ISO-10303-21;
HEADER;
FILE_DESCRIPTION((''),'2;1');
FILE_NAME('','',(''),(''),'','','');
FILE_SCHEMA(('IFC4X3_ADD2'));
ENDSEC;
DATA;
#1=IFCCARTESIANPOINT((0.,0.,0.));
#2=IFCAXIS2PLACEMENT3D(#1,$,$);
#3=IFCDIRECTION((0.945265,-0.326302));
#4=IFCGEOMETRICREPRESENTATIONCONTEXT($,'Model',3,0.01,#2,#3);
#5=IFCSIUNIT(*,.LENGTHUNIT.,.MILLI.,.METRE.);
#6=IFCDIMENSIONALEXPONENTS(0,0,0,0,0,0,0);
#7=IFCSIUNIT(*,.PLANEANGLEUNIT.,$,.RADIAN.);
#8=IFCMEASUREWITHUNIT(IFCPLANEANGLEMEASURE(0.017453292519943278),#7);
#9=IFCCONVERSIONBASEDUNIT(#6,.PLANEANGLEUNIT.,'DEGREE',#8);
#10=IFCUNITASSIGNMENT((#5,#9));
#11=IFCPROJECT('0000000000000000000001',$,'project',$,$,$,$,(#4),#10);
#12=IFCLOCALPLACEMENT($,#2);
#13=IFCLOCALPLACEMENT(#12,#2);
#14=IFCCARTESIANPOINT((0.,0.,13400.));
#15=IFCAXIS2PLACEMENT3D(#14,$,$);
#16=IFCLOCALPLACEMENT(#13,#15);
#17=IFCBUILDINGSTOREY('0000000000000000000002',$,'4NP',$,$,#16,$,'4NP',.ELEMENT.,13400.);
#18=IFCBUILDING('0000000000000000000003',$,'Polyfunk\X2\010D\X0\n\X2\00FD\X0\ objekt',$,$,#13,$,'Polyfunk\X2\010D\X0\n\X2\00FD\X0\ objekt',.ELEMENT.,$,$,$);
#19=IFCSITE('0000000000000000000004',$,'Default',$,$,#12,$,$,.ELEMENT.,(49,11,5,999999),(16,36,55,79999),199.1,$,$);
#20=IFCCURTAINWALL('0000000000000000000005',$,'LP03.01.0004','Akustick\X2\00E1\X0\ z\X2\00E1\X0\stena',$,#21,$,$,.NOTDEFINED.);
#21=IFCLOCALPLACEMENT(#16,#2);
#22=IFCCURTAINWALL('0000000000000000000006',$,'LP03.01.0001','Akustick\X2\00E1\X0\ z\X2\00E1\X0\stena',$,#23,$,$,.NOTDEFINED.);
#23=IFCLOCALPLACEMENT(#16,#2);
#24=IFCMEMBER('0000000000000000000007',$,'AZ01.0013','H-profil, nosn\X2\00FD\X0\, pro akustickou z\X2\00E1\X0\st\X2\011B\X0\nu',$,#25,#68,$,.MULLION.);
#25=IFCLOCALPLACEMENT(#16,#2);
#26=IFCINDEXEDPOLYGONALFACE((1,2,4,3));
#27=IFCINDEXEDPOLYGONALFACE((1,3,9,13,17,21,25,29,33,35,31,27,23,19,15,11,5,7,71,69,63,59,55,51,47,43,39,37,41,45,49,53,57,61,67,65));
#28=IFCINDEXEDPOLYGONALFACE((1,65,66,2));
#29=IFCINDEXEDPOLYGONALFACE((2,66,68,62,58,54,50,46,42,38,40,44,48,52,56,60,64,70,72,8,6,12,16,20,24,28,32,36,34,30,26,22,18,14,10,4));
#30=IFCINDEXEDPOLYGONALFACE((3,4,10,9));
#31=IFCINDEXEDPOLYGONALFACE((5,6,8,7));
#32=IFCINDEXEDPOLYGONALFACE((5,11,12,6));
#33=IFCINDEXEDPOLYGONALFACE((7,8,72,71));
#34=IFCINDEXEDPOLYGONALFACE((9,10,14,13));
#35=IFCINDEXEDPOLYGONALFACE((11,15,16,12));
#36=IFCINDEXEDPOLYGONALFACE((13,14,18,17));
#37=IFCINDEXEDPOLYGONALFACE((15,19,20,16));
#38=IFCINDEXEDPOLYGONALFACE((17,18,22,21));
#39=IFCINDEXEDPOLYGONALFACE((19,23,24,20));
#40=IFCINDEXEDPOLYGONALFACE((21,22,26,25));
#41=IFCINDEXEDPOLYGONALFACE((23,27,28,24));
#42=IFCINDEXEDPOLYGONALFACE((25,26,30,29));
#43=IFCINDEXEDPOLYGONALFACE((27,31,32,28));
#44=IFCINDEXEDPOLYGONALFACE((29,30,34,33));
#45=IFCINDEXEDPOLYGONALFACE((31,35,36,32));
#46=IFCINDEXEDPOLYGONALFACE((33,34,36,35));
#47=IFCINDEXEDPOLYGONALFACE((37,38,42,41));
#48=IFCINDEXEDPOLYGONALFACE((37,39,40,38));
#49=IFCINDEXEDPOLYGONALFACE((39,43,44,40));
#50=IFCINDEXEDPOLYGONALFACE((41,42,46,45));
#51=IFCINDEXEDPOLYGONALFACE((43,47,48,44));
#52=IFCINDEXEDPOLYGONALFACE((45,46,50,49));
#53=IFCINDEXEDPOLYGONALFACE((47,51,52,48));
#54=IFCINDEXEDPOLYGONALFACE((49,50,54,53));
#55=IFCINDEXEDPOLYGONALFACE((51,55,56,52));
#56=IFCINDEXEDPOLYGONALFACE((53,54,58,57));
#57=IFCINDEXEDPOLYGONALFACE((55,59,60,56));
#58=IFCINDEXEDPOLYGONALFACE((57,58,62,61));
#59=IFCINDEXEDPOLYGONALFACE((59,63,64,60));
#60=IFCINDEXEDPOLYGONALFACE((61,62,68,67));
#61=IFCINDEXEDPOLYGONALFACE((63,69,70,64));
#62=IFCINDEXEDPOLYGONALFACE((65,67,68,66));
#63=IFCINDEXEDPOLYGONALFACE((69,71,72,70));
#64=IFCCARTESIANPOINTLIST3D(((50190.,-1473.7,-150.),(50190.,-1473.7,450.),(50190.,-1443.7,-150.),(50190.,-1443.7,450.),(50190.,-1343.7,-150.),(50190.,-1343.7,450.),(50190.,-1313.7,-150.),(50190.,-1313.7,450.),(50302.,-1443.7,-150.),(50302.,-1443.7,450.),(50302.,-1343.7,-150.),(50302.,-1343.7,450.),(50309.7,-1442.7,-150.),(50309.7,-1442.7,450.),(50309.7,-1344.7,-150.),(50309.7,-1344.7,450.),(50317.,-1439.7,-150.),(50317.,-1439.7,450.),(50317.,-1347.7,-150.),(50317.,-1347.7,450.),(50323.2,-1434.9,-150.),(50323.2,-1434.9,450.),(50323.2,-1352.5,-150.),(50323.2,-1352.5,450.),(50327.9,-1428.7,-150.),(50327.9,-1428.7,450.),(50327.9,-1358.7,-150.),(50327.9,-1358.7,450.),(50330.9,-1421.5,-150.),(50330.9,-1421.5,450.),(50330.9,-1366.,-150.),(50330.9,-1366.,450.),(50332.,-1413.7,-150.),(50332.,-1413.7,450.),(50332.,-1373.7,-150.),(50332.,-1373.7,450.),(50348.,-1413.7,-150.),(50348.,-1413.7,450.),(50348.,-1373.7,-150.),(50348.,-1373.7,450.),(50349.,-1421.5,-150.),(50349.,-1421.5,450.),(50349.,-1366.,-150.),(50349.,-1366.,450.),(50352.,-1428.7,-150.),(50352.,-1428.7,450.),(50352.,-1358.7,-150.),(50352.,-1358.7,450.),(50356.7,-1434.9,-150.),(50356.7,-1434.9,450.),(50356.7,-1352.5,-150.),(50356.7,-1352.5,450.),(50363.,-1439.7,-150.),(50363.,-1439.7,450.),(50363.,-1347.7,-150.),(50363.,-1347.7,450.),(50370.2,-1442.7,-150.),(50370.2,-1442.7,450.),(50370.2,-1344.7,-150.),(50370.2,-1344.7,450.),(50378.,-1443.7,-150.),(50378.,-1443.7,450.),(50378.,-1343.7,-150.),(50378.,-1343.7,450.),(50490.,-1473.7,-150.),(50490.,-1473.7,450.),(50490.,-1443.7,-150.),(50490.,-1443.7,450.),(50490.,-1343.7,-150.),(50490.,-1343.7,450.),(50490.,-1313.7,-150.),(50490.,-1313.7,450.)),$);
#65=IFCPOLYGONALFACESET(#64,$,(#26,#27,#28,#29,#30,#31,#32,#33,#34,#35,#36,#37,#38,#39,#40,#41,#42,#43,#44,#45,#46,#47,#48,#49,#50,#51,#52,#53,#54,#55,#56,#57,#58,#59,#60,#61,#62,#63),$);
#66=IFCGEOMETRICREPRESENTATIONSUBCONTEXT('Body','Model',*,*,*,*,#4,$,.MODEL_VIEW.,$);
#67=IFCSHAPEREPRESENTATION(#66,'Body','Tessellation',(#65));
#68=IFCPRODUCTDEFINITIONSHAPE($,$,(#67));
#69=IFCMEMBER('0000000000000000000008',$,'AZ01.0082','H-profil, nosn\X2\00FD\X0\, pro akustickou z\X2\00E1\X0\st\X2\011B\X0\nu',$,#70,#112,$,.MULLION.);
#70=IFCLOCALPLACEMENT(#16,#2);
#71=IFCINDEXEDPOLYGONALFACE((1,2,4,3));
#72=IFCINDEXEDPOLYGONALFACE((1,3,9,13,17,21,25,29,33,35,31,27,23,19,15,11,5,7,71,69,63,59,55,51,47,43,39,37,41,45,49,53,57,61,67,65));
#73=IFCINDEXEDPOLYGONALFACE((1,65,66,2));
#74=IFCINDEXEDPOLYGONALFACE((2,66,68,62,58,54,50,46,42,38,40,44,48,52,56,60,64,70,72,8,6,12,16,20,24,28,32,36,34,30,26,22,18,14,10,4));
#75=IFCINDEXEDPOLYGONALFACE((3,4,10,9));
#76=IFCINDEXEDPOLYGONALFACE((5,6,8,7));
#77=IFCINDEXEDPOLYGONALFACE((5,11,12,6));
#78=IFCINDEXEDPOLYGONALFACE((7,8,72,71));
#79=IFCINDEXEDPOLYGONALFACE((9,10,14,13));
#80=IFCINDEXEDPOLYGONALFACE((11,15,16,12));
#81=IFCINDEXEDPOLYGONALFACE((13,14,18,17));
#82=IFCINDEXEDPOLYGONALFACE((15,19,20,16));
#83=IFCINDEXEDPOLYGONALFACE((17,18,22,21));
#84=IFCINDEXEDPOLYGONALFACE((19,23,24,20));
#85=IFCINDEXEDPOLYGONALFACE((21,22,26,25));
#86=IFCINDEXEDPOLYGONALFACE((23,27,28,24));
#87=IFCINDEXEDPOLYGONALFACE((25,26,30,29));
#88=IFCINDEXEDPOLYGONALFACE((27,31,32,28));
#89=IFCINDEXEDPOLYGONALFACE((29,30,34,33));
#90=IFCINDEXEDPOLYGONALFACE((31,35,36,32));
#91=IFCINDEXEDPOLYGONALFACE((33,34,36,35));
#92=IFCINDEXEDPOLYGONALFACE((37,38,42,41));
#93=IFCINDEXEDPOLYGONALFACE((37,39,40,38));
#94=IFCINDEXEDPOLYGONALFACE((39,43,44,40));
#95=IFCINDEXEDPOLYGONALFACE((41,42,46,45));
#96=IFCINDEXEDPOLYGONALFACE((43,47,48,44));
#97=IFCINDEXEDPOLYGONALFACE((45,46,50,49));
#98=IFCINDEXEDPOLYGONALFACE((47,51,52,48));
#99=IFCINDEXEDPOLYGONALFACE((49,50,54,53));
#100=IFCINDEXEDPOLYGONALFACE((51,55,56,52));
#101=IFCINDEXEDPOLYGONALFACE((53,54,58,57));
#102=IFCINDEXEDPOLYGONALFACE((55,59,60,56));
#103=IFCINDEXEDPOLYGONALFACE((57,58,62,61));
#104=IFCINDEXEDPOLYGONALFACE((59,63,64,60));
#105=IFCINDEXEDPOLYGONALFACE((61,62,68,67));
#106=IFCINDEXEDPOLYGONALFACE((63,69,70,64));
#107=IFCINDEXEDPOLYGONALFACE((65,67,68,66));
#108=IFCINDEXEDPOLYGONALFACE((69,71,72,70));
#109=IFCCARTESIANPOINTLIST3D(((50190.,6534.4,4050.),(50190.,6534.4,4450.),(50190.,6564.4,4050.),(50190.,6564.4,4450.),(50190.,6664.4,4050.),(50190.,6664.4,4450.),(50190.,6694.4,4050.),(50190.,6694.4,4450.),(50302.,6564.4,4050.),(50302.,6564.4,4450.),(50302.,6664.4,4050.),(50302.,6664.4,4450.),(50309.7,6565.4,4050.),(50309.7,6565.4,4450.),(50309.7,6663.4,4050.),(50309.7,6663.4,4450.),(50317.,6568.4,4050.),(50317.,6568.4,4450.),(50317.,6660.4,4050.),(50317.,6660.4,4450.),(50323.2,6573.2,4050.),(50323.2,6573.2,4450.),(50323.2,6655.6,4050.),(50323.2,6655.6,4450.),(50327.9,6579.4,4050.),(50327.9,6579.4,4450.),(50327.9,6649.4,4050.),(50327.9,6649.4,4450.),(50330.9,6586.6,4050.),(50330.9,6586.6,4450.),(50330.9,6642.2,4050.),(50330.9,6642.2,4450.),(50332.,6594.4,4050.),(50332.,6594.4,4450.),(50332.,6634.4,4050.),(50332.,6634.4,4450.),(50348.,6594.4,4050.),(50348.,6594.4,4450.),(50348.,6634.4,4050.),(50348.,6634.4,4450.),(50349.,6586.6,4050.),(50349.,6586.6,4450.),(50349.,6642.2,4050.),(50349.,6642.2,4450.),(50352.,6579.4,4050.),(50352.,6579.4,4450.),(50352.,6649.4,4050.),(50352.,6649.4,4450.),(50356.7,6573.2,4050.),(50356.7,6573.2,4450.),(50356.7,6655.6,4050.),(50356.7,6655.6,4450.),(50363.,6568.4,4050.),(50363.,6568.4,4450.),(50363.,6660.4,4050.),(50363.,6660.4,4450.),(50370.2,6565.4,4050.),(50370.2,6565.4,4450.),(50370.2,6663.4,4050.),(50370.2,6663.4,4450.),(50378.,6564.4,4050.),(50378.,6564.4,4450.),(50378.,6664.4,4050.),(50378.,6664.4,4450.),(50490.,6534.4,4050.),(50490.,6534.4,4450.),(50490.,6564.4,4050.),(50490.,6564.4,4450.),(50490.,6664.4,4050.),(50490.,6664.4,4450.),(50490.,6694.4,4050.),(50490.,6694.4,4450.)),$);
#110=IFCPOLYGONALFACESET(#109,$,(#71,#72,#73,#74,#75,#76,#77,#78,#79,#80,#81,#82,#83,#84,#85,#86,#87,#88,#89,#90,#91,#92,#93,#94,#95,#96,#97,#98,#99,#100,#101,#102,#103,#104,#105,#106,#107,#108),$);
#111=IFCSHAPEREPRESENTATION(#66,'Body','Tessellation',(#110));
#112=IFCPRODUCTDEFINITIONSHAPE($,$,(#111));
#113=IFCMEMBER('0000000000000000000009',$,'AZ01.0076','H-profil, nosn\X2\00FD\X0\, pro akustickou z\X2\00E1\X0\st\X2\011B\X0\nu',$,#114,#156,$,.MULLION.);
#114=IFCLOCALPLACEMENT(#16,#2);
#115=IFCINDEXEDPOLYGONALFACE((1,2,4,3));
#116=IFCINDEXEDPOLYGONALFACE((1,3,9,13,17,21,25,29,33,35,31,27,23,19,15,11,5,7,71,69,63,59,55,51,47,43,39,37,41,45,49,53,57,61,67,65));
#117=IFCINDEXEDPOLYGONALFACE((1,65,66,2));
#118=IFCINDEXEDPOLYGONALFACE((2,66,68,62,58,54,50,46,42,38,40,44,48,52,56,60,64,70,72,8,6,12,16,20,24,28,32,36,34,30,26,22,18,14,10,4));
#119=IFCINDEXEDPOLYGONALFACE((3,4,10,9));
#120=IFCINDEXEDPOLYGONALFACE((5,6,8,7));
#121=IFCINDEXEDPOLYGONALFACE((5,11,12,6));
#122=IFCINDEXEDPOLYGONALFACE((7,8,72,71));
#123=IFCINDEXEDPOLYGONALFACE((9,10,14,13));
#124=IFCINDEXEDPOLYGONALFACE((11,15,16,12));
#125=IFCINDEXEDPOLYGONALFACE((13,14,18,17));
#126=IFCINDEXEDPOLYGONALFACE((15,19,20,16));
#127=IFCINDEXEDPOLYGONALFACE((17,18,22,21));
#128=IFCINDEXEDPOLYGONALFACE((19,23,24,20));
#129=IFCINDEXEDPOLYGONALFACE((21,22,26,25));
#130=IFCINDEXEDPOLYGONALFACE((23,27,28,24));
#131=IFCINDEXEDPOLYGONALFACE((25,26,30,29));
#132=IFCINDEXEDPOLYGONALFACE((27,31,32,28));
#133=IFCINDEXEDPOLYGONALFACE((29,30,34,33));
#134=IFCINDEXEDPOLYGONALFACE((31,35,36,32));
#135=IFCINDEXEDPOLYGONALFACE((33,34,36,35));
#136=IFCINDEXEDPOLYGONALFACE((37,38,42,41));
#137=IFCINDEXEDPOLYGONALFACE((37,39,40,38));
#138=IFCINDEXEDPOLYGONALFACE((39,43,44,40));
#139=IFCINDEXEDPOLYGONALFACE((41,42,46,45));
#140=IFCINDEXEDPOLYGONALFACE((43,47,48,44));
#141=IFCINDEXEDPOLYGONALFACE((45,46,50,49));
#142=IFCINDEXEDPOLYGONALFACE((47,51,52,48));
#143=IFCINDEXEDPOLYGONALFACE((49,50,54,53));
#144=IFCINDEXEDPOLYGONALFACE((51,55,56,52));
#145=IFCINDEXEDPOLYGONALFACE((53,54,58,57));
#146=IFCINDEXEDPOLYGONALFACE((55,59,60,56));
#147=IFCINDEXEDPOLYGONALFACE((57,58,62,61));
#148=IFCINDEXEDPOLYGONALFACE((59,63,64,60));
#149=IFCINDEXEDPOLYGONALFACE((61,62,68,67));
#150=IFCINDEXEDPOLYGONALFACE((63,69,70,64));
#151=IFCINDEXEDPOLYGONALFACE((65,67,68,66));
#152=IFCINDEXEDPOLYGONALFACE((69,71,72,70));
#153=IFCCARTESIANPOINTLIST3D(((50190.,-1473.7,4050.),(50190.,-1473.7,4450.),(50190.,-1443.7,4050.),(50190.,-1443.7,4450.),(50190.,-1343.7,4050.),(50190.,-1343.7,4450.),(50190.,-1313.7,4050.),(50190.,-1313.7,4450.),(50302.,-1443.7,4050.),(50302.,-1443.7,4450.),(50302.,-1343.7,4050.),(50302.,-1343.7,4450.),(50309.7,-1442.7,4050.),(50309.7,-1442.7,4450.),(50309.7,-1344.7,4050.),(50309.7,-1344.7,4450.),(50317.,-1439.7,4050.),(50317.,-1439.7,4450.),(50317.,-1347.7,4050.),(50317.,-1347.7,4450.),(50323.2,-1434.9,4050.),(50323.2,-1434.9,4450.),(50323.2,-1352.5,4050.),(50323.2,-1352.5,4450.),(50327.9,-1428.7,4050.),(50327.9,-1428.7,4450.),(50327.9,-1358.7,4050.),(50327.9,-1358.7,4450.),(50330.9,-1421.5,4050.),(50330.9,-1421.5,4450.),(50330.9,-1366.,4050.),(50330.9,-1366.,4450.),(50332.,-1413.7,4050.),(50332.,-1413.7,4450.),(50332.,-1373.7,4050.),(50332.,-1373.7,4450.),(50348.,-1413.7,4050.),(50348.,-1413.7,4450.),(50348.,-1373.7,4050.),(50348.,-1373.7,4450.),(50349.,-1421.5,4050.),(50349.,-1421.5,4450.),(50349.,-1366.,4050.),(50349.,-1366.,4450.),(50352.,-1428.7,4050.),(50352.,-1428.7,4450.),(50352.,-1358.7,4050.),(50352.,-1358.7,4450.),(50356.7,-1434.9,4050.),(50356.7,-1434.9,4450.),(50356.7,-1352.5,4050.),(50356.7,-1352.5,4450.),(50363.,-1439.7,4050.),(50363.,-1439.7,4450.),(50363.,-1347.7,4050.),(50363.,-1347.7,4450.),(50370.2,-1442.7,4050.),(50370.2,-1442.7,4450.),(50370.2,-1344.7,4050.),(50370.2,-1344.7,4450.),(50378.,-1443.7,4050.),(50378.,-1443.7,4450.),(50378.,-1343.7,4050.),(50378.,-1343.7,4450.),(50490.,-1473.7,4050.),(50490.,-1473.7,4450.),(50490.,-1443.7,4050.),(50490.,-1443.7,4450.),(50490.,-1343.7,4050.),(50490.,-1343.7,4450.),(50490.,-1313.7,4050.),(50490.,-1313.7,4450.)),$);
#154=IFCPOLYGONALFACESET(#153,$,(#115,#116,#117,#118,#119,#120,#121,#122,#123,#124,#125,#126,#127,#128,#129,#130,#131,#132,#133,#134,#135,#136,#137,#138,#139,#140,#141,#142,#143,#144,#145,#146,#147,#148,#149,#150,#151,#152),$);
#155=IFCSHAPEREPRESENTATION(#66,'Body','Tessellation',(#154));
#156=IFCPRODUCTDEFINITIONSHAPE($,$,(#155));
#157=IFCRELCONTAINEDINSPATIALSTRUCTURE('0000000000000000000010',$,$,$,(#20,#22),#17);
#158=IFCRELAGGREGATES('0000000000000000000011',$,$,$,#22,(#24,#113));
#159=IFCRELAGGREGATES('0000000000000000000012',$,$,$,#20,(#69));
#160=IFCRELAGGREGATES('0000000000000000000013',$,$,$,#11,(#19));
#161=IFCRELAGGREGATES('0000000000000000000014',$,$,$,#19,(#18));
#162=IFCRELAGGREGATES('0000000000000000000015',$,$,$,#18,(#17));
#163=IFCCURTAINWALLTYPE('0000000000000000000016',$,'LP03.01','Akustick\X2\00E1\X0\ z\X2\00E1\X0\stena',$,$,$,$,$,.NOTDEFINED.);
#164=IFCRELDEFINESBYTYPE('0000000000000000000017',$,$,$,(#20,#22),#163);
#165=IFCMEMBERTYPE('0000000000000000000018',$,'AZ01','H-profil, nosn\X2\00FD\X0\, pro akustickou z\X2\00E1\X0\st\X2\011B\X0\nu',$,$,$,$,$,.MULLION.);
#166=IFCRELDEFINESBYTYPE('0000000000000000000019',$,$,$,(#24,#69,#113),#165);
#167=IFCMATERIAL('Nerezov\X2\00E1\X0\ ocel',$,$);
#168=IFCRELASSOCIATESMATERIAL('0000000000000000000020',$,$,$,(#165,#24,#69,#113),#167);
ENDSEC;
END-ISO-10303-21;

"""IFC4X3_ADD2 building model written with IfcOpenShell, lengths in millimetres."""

from ifc_helpers import new_model, entity, si_unit, converted_unit, direction, frame, frame_2d, origin, place, context, subcontext, project, spatial, polyline, circle_curve, parameter, trimmed, segment, composite_curve, outline, extrude, source, transform, mapped, material, material_profile, profile_set, profile_usage, type_object, element, aggregate, save


model = new_model("IFC4X3_ADD2")

# Units and contexts
model_context = context("Model", 3, precision=0.01, world=origin(), true_north=direction((0.945265, -0.326302)))
body_context = subcontext(model_context, "Body", "Model", "MODEL_VIEW")
ifc_project = project(units=[si_unit("LENGTHUNIT", "METRE", prefix="MILLI"), converted_unit("PLANEANGLEUNIT", "DEGREE", entity("IfcPlaneAngleMeasure", 0.017453292519943278), si_unit("PLANEANGLEUNIT", "RADIAN"), dimensions=[0, 0, 0, 0, 0, 0, 0])], contexts=[model_context])

# Site, building, storey
site_placement = place(None, origin())
site = spatial("IfcSite", under=ifc_project, at=site_placement, Name="Default", CompositionType="ELEMENT", RefLatitude=(49, 11, 5, 999999), RefLongitude=(16, 36, 55, 79999), RefElevation=199.1)
building_placement = place(site_placement, origin())
building = spatial("IfcBuilding", under=site, at=building_placement, Name="Polyfunkčný objekt", LongName="Polyfunkčný objekt", CompositionType="ELEMENT")
storey_placement = place(building_placement, frame((0.0, 0.0, 13400.0)))
storey = spatial("IfcBuildingStorey", under=building, at=storey_placement, Name="4NP", LongName="4NP", CompositionType="ELEMENT", Elevation=13400.0)

# Curtain walls
curtain_wall_type = type_object("IfcCurtainWallType", Name="LP03.01", Description="Akustická zástena", PredefinedType="NOTDEFINED")
curtain_wall_1_placement = place(storey_placement, frame((0.0, 0.0, -13400.0)))
curtain_wall_1 = element("IfcCurtainWall", 1, at=curtain_wall_1_placement, inside=storey, type_object=curtain_wall_type, Name="LP03.01.0004", Description="Akustická zástena", PredefinedType="NOTDEFINED")
ifc_material_1 = material(Name="Nerezová ocel")
ifc_material_profile = material_profile(ifc_material_1, outline(composite_curve([segment(polyline([(50.0, -150.0), (80.0, -150.0)]), True, "CONTINUOUS"), segment(polyline([(80.0, -150.0), (80.0, 150.0)]), True, "CONTINUOUS"), segment(polyline([(80.0, 150.0), (50.0, 150.0)]), True, "CONTINUOUS"), segment(polyline([(50.0, 150.0), (50.0, 38.0)]), True, "CONTINUOUS"), segment(trimmed(circle_curve(frame_2d((20.0, 38.0), x_axis=(0.0, 1.0)), 30.0), [parameter(180.0)], [parameter(270.0)], True, "PARAMETER"), False, "CONTINUOUS"), segment(polyline([(20.0, 8.0), (-20.0, 8.0)]), True, "CONTINUOUS"), segment(trimmed(circle_curve(frame_2d((-20.0, 38.0), x_axis=(0.0, 1.0)), 30.0), [parameter(90.0)], [parameter(180.0)], True, "PARAMETER"), False, "CONTINUOUS"), segment(polyline([(-50.0, 38.0), (-50.0, 150.0)]), True, "CONTINUOUS"), segment(polyline([(-50.0, 150.0), (-80.0, 150.0)]), True, "CONTINUOUS"), segment(polyline([(-80.0, 150.0), (-80.0, -150.0)]), True, "CONTINUOUS"), segment(polyline([(-80.0, -150.0), (-50.0, -150.0)]), True, "CONTINUOUS"), segment(polyline([(-50.0, -150.0), (-50.0, -38.0)]), True, "CONTINUOUS"), segment(trimmed(circle_curve(frame_2d((-20.0, -38.0), x_axis=(0.0, 1.0)), 30.0), [parameter(0.0)], [parameter(90.0)], True, "PARAMETER"), False, "CONTINUOUS"), segment(polyline([(-20.0, -8.0), (20.0, -8.0)]), True, "CONTINUOUS"), segment(trimmed(circle_curve(frame_2d((20.0, -38.0), x_axis=(0.0, 1.0)), 30.0), [parameter(270.0)], [parameter(0.0)], True, "PARAMETER"), False, "CONTINUOUS"), segment(polyline([(50.0, -38.0), (50.0, -150.0)]), True, "CONTINUOUS")], self_intersect=False)), Name="Profil zástena")
ifc_profile_set = profile_set([ifc_material_profile], Name="Profil zástena")
ifc_profile_usage = profile_usage(ifc_profile_set)
member_type = type_object("IfcMemberType", Name="AZ01", Description="H-profil, nosný, pro akustickou zástěnu", PredefinedType="MULLION", material=ifc_profile_set)
curtain_wall_2_placement = place(storey_placement, frame((0.0, 0.0, -13400.0)))
curtain_wall_2 = element("IfcCurtainWall", 2, at=curtain_wall_2_placement, inside=storey, type_object=curtain_wall_type, Name="LP03.01.0001", Description="Akustická zástena", PredefinedType="NOTDEFINED")

# Members
shared_shape_1 = source(origin(), body_context, "Body", "SweptSolid", [
    extrude(outline(composite_curve([segment(polyline([(-150.0, -50.0), (-150.0, -80.0)]), True, "CONTINUOUS"), segment(polyline([(-150.0, -80.0), (150.0, -80.0)]), True, "CONTINUOUS"), segment(polyline([(150.0, -80.0), (150.0, -50.0)]), True, "CONTINUOUS"), segment(polyline([(150.0, -50.0), (38.0, -50.0)]), True, "CONTINUOUS"), segment(trimmed(circle_curve(frame_2d((38.0, -20.0), x_axis=(1.0, 0.0)), 30.0), [parameter(180.0)], [parameter(270.0)], True, "PARAMETER"), False, "CONTINUOUS"), segment(polyline([(8.0, -20.0), (8.0, 20.0)]), True, "CONTINUOUS"), segment(trimmed(circle_curve(frame_2d((38.0, 20.0), x_axis=(1.0, 0.0)), 30.0), [parameter(90.0)], [parameter(180.0)], True, "PARAMETER"), False, "CONTINUOUS"), segment(polyline([(38.0, 50.0), (150.0, 50.0)]), True, "CONTINUOUS"), segment(polyline([(150.0, 50.0), (150.0, 80.0)]), True, "CONTINUOUS"), segment(polyline([(150.0, 80.0), (-150.0, 80.0)]), True, "CONTINUOUS"), segment(polyline([(-150.0, 80.0), (-150.0, 50.0)]), True, "CONTINUOUS"), segment(polyline([(-150.0, 50.0), (-38.0, 50.0)]), True, "CONTINUOUS"), segment(trimmed(circle_curve(frame_2d((-38.0, 20.0), x_axis=(1.0, 0.0)), 30.0), [parameter(0.0)], [parameter(90.0)], True, "PARAMETER"), False, "CONTINUOUS"), segment(polyline([(-8.0, 20.0), (-8.0, -20.0)]), True, "CONTINUOUS"), segment(trimmed(circle_curve(frame_2d((-38.0, -20.0), x_axis=(1.0, 0.0)), 30.0), [parameter(270.0)], [parameter(0.0)], True, "PARAMETER"), False, "CONTINUOUS"), segment(polyline([(-38.0, -50.0), (-150.0, -50.0)]), True, "CONTINUOUS")], self_intersect=False)), frame((-150.0, 0.0, -600.0), z_axis=(0.0, 0.0, -1.0), x_axis=(-1.0, 0.0, 0.0)), (0.0, 0.0, -1.0), 600.0),
])
member_1_placement = place(curtain_wall_2_placement, frame((50190.0, -1393.7, 13850.0), z_axis=(0.0, 0.0, 1.0), x_axis=(-1.0, 0.0, 0.0)))
member_1 = element("IfcMember", 3, at=member_1_placement, type_object=member_type, material=ifc_profile_usage, Name="AZ01.0013", Description="H-profil, nosný, pro akustickou zástěnu", PredefinedType="MULLION", context=body_context, shape_type="MappedRepresentation", body=[
    mapped(shared_shape_1, transform((0.0, 0.0, 0.0), scale=1.0)),
])
shared_shape_2 = source(origin(), body_context, "Body", "SweptSolid", [
    extrude(outline(composite_curve([segment(polyline([(-150.0, -50.0), (-150.0, -80.0)]), True, "CONTINUOUS"), segment(polyline([(-150.0, -80.0), (150.0, -80.0)]), True, "CONTINUOUS"), segment(polyline([(150.0, -80.0), (150.0, -50.0)]), True, "CONTINUOUS"), segment(polyline([(150.0, -50.0), (38.0, -50.0)]), True, "CONTINUOUS"), segment(trimmed(circle_curve(frame_2d((38.0, -20.0), x_axis=(1.0, 0.0)), 30.0), [parameter(180.0)], [parameter(270.0)], True, "PARAMETER"), False, "CONTINUOUS"), segment(polyline([(8.0, -20.0), (8.0, 20.0)]), True, "CONTINUOUS"), segment(trimmed(circle_curve(frame_2d((38.0, 20.0), x_axis=(1.0, 0.0)), 30.0), [parameter(90.0)], [parameter(180.0)], True, "PARAMETER"), False, "CONTINUOUS"), segment(polyline([(38.0, 50.0), (150.0, 50.0)]), True, "CONTINUOUS"), segment(polyline([(150.0, 50.0), (150.0, 80.0)]), True, "CONTINUOUS"), segment(polyline([(150.0, 80.0), (-150.0, 80.0)]), True, "CONTINUOUS"), segment(polyline([(-150.0, 80.0), (-150.0, 50.0)]), True, "CONTINUOUS"), segment(polyline([(-150.0, 50.0), (-38.0, 50.0)]), True, "CONTINUOUS"), segment(trimmed(circle_curve(frame_2d((-38.0, 20.0), x_axis=(1.0, 0.0)), 30.0), [parameter(0.0)], [parameter(90.0)], True, "PARAMETER"), False, "CONTINUOUS"), segment(polyline([(-8.0, 20.0), (-8.0, -20.0)]), True, "CONTINUOUS"), segment(trimmed(circle_curve(frame_2d((-38.0, -20.0), x_axis=(1.0, 0.0)), 30.0), [parameter(270.0)], [parameter(0.0)], True, "PARAMETER"), False, "CONTINUOUS"), segment(polyline([(-38.0, -50.0), (-150.0, -50.0)]), True, "CONTINUOUS")], self_intersect=False)), frame((-150.0, 0.0, -400.0), z_axis=(0.0, 0.0, -1.0), x_axis=(-1.0, 0.0, 0.0)), (0.0, 0.0, -1.0), 400.0),
])
member_2_placement = place(curtain_wall_1_placement, frame((50190.0, 6614.4, 17850.0), z_axis=(0.0, 0.0, 1.0), x_axis=(-1.0, 0.0, 0.0)))
member_2 = element("IfcMember", 4, at=member_2_placement, type_object=member_type, material=ifc_profile_usage, Name="AZ01.0082", Description="H-profil, nosný, pro akustickou zástěnu", PredefinedType="MULLION", context=body_context, shape_type="MappedRepresentation", body=[
    mapped(shared_shape_2, transform((0.0, 0.0, 0.0), scale=1.0)),
])
member_3_placement = place(curtain_wall_2_placement, frame((50190.0, -1393.7, 17850.0), z_axis=(0.0, 0.0, 1.0), x_axis=(-1.0, 0.0, 0.0)))
member_3 = element("IfcMember", 5, at=member_3_placement, type_object=member_type, material=ifc_profile_usage, Name="AZ01.0076", Description="H-profil, nosný, pro akustickou zástěnu", PredefinedType="MULLION", context=body_context, shape_type="MappedRepresentation", body=[
    mapped(shared_shape_2, transform((0.0, 0.0, 0.0), scale=1.0)),
])
aggregate(curtain_wall_2, [member_1, member_3])

aggregate(curtain_wall_1, [member_2])

save(model, "model.ifc")
